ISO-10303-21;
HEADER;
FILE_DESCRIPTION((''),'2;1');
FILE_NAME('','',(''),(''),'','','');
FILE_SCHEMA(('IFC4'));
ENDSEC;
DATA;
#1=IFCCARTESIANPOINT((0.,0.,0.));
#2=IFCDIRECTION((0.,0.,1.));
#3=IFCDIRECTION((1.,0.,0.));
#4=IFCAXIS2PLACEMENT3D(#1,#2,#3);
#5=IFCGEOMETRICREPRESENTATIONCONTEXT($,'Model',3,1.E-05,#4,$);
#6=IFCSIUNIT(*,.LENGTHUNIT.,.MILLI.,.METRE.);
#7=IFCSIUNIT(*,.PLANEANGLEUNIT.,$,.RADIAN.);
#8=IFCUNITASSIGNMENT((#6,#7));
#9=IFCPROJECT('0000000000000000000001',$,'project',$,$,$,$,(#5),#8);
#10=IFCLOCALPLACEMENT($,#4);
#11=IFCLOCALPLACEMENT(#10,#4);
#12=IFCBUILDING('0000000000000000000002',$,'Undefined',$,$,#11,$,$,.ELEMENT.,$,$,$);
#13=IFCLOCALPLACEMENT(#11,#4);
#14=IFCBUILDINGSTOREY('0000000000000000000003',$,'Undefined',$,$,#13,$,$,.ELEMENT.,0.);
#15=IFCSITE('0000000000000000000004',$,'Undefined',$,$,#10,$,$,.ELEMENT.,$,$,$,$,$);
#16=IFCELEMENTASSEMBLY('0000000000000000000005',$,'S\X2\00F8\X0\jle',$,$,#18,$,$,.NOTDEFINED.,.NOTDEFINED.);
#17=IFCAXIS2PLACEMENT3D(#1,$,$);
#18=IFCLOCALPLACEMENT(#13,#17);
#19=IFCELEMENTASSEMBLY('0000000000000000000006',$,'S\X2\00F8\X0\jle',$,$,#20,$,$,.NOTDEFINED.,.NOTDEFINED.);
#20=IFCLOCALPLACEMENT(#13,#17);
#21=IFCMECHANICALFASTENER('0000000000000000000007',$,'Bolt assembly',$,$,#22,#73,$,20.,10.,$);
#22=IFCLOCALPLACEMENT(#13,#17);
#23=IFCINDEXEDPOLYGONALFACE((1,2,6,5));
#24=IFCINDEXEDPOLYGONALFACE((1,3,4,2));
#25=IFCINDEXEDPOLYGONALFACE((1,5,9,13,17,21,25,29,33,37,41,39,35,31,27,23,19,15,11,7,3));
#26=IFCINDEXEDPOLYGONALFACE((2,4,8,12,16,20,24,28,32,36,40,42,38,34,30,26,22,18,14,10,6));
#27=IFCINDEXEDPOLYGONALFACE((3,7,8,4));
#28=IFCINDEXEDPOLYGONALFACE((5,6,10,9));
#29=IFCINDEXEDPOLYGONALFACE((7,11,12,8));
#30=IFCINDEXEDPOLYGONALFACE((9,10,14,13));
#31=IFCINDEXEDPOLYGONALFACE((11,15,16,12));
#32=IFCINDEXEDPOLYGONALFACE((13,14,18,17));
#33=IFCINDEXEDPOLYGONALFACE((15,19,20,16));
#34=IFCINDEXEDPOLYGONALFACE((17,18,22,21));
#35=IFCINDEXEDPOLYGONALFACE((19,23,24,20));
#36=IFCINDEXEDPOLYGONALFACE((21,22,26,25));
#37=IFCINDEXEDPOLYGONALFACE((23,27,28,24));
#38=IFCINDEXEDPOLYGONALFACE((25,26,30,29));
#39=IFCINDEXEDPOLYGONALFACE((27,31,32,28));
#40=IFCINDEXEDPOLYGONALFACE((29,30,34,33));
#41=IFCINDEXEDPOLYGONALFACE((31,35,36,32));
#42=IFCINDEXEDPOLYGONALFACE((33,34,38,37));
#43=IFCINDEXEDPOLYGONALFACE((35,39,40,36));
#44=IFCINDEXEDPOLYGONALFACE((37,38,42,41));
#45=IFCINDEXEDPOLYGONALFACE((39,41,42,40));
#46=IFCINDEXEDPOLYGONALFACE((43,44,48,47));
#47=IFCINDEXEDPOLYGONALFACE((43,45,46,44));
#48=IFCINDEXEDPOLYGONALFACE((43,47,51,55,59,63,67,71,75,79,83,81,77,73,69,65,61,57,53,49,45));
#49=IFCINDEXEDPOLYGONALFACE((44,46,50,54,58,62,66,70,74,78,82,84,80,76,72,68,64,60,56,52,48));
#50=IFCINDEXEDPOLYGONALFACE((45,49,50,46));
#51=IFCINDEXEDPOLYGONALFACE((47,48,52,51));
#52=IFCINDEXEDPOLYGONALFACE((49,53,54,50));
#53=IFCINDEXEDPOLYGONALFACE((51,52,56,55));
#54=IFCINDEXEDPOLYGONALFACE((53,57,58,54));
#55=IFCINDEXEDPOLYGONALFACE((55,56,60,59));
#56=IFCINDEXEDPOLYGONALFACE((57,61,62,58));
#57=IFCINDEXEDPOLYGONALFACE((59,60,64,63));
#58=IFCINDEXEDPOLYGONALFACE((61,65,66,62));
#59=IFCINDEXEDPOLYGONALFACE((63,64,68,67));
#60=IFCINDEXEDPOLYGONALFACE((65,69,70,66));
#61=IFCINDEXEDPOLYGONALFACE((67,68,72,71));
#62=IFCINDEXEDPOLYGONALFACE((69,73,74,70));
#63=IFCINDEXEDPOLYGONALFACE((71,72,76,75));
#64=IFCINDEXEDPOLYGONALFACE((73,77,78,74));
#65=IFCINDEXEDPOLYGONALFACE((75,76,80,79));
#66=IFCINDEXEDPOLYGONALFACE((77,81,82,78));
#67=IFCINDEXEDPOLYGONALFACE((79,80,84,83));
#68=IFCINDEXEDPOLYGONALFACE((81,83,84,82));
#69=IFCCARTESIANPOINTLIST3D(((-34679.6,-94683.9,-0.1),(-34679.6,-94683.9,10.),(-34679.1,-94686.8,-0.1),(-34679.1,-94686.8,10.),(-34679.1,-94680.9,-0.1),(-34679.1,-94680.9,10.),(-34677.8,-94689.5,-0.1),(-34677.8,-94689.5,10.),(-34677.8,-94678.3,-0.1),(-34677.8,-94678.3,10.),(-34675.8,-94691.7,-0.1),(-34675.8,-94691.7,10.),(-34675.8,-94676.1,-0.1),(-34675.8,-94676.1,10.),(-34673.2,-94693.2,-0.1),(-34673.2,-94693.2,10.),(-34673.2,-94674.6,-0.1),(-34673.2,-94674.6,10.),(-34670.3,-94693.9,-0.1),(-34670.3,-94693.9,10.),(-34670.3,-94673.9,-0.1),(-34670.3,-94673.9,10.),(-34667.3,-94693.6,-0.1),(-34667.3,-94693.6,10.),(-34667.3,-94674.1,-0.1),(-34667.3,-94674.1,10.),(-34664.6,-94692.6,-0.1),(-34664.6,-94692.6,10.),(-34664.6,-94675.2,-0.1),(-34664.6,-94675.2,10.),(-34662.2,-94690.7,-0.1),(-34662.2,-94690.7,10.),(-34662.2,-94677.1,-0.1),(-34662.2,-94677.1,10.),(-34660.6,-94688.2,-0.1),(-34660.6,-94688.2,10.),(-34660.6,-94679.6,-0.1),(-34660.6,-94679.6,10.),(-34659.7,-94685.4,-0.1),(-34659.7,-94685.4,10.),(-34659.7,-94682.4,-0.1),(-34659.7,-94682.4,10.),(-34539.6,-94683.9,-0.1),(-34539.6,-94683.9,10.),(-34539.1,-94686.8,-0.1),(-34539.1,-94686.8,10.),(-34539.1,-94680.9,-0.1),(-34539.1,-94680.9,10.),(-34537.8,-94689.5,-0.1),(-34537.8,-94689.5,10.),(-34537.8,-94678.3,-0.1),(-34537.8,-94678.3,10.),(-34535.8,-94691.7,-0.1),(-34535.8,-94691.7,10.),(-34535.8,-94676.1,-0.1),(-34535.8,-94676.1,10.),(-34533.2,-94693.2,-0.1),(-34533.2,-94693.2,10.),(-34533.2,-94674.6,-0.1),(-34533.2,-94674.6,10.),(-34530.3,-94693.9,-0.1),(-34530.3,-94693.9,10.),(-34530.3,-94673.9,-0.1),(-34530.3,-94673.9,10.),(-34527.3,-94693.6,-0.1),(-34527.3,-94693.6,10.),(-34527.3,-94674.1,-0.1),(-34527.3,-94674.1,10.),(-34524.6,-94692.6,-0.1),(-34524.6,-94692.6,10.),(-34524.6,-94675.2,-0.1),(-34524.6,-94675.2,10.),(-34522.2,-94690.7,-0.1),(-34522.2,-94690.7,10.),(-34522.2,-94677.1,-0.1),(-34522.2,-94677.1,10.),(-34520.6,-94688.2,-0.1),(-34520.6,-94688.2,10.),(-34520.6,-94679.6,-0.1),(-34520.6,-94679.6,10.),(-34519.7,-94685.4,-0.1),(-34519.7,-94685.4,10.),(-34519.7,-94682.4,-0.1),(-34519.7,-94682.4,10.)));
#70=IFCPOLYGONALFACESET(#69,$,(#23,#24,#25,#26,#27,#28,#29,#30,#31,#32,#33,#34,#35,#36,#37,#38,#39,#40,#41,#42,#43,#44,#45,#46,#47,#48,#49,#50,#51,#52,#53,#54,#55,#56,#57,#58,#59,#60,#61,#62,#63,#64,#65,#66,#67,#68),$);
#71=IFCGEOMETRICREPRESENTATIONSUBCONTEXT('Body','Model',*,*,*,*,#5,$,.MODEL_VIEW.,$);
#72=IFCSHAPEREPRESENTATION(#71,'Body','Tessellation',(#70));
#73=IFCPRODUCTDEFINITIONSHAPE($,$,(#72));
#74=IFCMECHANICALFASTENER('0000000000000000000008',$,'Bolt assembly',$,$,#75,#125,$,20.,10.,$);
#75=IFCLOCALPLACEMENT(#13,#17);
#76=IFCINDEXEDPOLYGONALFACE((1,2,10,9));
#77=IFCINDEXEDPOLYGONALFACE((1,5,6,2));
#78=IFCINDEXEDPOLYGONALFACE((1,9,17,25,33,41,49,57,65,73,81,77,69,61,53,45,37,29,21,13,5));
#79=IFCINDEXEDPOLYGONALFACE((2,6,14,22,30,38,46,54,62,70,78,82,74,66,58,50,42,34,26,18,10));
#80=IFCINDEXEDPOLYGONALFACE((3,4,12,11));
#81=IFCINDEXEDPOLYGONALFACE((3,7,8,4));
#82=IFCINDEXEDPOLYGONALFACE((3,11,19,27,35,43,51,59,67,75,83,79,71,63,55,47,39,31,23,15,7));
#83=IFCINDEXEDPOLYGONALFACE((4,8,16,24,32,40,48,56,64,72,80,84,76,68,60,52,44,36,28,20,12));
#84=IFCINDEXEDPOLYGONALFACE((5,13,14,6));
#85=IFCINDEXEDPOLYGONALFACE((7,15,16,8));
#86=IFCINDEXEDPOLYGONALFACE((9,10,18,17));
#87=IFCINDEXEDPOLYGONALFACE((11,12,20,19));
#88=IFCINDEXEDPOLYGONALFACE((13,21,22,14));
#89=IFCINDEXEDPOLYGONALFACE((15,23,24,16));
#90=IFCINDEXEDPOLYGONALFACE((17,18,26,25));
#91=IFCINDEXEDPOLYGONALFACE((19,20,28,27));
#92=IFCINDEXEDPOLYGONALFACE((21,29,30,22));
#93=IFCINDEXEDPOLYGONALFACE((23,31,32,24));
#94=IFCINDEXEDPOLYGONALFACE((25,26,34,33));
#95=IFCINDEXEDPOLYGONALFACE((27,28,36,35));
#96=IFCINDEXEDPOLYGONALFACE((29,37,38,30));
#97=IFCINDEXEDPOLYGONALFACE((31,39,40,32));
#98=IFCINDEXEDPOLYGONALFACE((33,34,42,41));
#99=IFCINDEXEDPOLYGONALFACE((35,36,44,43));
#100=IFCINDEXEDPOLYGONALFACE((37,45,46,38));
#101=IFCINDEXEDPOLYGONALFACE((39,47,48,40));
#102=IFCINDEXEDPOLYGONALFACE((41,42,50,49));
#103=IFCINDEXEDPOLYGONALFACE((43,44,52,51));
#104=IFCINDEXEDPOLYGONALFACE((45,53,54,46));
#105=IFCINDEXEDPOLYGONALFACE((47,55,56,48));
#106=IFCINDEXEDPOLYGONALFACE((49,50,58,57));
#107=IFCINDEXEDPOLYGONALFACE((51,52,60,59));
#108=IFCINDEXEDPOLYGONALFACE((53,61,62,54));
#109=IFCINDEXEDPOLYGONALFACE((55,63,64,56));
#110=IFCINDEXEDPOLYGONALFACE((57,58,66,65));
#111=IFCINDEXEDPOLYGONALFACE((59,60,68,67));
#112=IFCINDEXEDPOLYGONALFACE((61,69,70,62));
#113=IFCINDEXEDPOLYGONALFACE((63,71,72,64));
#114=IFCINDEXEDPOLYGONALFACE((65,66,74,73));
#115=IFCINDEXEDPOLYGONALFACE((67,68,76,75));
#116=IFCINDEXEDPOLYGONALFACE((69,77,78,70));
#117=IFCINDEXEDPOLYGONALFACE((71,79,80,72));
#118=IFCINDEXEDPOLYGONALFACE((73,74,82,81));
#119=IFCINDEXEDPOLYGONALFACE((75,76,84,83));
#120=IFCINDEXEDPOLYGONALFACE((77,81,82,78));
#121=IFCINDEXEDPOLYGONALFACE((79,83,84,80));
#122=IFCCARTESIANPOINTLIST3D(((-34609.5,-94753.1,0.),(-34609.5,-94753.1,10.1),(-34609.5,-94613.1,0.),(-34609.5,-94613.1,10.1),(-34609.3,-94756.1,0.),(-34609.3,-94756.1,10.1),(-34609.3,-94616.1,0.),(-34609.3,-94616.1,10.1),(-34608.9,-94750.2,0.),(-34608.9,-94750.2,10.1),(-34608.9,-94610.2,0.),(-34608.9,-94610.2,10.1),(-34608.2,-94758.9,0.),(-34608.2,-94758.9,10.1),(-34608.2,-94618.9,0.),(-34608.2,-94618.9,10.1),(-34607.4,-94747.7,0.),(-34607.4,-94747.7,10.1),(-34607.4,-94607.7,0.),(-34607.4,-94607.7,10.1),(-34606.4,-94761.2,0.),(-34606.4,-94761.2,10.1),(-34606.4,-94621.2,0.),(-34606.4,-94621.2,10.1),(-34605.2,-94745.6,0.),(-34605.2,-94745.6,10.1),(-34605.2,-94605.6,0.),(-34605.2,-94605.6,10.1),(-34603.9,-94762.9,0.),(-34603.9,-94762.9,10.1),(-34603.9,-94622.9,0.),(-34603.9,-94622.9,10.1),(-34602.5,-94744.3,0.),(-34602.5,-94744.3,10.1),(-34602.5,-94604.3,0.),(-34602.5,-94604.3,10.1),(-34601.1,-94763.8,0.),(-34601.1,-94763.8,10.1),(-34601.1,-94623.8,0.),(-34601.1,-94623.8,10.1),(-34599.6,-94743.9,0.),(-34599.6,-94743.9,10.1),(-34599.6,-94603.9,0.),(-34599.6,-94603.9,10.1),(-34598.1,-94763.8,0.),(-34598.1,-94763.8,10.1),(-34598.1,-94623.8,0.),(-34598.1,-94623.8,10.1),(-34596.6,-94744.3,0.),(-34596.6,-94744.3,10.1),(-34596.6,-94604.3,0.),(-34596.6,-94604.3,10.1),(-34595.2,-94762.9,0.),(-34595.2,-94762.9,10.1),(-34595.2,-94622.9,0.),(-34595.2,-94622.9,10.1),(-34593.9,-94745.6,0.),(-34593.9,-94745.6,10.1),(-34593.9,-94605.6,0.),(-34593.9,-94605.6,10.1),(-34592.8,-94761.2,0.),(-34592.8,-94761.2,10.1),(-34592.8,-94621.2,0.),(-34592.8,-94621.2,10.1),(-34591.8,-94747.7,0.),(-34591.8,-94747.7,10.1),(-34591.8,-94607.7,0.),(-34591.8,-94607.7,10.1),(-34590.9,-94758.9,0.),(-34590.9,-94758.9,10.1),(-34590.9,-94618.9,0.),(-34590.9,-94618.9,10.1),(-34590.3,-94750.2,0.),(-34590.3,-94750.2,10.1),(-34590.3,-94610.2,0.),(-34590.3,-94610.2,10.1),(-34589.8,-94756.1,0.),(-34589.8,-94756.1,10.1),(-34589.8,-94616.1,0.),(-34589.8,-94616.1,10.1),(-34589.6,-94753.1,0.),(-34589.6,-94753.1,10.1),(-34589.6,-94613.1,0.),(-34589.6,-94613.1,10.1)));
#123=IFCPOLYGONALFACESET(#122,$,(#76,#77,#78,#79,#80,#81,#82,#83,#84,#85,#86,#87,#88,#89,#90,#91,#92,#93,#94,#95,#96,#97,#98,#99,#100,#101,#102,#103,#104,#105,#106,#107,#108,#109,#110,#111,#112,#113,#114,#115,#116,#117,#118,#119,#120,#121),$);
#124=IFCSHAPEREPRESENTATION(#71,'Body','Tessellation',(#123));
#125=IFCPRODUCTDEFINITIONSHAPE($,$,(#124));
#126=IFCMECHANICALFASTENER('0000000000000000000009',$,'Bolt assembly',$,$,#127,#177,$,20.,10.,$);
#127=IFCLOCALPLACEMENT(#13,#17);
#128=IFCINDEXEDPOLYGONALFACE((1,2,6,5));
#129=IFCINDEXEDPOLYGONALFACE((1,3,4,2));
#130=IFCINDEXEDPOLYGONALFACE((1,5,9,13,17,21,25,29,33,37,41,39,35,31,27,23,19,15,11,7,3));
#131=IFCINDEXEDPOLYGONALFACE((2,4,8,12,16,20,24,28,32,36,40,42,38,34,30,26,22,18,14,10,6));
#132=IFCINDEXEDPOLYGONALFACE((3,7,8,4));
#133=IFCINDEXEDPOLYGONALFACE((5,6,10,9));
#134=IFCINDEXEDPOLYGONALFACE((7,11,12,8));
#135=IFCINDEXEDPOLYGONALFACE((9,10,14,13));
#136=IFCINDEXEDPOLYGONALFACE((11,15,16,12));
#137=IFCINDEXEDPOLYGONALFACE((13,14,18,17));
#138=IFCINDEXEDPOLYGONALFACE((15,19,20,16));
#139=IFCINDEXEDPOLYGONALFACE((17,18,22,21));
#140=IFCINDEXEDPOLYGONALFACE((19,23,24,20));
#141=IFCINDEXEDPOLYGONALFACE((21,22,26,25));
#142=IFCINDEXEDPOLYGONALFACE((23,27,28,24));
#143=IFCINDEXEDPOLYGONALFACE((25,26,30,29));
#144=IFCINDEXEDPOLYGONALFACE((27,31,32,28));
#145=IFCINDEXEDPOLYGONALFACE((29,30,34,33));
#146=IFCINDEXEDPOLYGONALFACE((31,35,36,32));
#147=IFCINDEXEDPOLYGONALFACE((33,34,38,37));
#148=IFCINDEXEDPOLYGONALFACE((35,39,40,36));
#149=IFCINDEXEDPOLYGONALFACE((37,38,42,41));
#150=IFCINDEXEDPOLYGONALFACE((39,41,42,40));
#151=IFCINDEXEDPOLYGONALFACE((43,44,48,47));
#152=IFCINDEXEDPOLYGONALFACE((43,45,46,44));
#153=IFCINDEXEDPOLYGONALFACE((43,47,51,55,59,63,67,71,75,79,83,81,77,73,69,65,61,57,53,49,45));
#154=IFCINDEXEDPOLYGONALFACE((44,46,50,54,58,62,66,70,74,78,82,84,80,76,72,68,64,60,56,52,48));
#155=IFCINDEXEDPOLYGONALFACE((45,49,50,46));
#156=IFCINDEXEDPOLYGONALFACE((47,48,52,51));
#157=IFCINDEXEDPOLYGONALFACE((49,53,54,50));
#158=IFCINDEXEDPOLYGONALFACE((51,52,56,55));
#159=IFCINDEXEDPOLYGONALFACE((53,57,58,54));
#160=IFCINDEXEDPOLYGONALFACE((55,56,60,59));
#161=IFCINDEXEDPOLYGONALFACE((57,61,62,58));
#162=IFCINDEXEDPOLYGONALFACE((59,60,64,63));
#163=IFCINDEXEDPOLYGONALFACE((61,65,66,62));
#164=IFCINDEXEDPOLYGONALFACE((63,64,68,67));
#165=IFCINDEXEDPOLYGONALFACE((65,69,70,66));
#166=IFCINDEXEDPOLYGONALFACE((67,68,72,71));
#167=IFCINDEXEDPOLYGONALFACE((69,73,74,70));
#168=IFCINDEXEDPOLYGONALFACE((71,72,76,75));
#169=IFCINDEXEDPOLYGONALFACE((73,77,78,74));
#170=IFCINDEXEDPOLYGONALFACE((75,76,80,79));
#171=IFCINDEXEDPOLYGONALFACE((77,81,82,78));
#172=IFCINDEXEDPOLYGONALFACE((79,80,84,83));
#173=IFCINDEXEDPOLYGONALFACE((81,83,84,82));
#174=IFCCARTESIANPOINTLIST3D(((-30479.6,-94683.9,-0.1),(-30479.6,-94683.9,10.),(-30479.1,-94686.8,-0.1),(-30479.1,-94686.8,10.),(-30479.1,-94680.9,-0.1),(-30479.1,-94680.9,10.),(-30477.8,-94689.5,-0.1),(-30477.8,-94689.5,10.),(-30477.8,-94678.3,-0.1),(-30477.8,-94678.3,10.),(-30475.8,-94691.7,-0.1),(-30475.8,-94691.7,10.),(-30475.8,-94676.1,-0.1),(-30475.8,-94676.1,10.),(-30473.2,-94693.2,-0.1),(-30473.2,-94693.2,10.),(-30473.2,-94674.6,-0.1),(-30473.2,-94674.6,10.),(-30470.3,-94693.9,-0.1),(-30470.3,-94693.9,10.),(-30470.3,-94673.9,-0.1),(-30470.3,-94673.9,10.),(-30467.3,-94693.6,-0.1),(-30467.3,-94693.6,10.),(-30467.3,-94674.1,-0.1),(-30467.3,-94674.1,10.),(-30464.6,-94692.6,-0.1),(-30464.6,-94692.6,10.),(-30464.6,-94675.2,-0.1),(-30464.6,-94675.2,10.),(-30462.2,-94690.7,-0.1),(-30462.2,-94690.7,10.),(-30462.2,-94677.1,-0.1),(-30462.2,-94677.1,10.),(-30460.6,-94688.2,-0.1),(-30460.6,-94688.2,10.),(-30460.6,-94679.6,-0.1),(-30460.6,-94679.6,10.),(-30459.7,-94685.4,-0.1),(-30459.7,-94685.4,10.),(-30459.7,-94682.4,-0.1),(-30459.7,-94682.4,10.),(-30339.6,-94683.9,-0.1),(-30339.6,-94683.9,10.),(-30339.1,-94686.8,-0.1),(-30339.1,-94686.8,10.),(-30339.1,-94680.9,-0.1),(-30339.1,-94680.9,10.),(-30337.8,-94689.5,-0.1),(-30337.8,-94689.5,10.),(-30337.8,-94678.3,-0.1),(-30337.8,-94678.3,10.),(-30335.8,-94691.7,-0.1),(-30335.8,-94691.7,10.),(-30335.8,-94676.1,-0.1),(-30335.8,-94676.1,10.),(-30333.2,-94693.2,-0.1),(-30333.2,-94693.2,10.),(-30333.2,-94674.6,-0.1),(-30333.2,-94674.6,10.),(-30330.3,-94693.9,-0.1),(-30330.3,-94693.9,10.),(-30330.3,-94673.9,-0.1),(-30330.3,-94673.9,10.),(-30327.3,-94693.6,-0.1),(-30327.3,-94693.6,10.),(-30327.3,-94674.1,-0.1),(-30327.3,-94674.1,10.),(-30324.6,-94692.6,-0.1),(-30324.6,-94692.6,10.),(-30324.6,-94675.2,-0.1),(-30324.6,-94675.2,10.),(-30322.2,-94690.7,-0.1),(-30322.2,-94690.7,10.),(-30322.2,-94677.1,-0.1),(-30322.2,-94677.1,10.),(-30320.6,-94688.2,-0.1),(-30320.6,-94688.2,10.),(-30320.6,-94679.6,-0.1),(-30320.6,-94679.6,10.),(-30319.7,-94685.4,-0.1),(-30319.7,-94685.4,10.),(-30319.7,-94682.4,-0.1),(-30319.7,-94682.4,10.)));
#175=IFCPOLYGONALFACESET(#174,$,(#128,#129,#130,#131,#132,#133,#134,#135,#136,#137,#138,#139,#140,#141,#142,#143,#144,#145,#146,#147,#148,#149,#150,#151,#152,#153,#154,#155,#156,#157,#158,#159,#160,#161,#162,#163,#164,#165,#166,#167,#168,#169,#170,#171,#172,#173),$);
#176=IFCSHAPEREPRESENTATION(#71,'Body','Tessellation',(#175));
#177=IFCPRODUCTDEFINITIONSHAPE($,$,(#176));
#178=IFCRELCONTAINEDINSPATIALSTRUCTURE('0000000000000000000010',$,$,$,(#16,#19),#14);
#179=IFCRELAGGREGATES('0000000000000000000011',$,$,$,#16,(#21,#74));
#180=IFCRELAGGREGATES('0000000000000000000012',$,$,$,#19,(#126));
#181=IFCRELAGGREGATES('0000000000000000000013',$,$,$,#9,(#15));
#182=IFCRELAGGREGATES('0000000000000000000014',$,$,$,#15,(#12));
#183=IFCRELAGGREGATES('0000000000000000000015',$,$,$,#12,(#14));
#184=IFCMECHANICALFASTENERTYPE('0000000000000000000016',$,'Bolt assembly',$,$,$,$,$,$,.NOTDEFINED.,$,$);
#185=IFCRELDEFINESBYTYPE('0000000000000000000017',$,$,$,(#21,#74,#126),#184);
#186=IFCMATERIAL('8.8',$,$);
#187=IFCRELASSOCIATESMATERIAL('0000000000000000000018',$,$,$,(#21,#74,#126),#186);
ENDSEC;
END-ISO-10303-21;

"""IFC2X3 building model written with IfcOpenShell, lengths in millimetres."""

from ifc_helpers import new_model, si_unit, frame, origin_with_axes, origin_2d_with_axis, place, context, subcontext, project, spatial, circle, extrude, source, transform, mapped, material, type_object, element, aggregate, save


model = new_model("IFC2X3")

# Units and contexts
model_context = context("Model", 3, precision=1e-05, world=origin_with_axes())
body_context = subcontext(model_context, "Body", "Model", "MODEL_VIEW")
ifc_project = project(units=[si_unit("LENGTHUNIT", "METRE", prefix="MILLI"), si_unit("PLANEANGLEUNIT", "RADIAN")], contexts=[model_context])

# Site, building, storey
site_placement = place(None, origin_with_axes())
site = spatial("IfcSite", under=ifc_project, at=site_placement, Name="Undefined", CompositionType="ELEMENT")
building_placement = place(site_placement, origin_with_axes())
building = spatial("IfcBuilding", under=site, at=building_placement, Name="Undefined", CompositionType="ELEMENT")
storey_placement = place(building_placement, origin_with_axes())
storey = spatial("IfcBuildingStorey", under=building, at=storey_placement, Name="Undefined", CompositionType="ELEMENT", Elevation=0.0)

# Element assemblies
assembly_1_placement = place(storey_placement, origin_with_axes())
assembly_1 = element("IfcElementAssembly", 1, at=assembly_1_placement, inside=storey, Name="Søjle", AssemblyPlace="NOTDEFINED", PredefinedType="NOTDEFINED")
assembly_2_placement = place(storey_placement, origin_with_axes())
assembly_2 = element("IfcElementAssembly", 2, at=assembly_2_placement, inside=storey, Name="Søjle", AssemblyPlace="NOTDEFINED", PredefinedType="NOTDEFINED")

# Mechanical fasteners
ifc_material_1 = material(Name="8.8")
mechanical_fastener_type = type_object("IfcMechanicalFastenerType", Name="Bolt assembly")
shared_shape_1 = source(origin_with_axes(), body_context, "Body", "SweptSolid", [
    extrude(circle(Radius=10.0, at=origin_2d_with_axis()), frame((0.0, -10.0, 0.0), z_axis=(0.0, 1.0, 0.0), x_axis=(1.0, 0.0, 0.0)), (0.0, 0.0, 1.0), 10.1),
])
mechanical_fastener_1_placement = place(assembly_1_placement, frame((-34529.6, -94683.9, 0.0), z_axis=(0.0, -1.0, 0.0), x_axis=(-1.0, 0.0, 0.0)))
mechanical_fastener_1 = element("IfcMechanicalFastener", 3, at=mechanical_fastener_1_placement, type_object=mechanical_fastener_type, material=ifc_material_1, Name="Bolt assembly", NominalDiameter=20.0, NominalLength=10.0, context=body_context, shape_type="MappedRepresentation", body=[
    mapped(shared_shape_1, transform((0.0, 0.0, 0.0))),
    mapped(shared_shape_1, transform((140.0, 0.0, 0.0))),
])
mechanical_fastener_2_placement = place(assembly_1_placement, frame((-34599.6, -94753.9, 10.0), z_axis=(1.0, 0.0, 0.0), x_axis=(0.0, 1.0, 0.0)))
mechanical_fastener_2 = element("IfcMechanicalFastener", 4, at=mechanical_fastener_2_placement, type_object=mechanical_fastener_type, material=ifc_material_1, Name="Bolt assembly", NominalDiameter=20.0, NominalLength=10.0, context=body_context, shape_type="MappedRepresentation", body=[
    mapped(shared_shape_1, transform((0.0, 0.0, 0.0))),
    mapped(shared_shape_1, transform((140.0, 0.0, 0.0))),
])
mechanical_fastener_3_placement = place(assembly_2_placement, frame((-30329.6, -94683.9, 0.0), z_axis=(0.0, -1.0, 0.0), x_axis=(-1.0, 0.0, 0.0)))
mechanical_fastener_3 = element("IfcMechanicalFastener", 5, at=mechanical_fastener_3_placement, type_object=mechanical_fastener_type, material=ifc_material_1, Name="Bolt assembly", NominalDiameter=20.0, NominalLength=10.0, context=body_context, shape_type="MappedRepresentation", body=[
    mapped(shared_shape_1, transform((0.0, 0.0, 0.0))),
    mapped(shared_shape_1, transform((140.0, 0.0, 0.0))),
])
aggregate(assembly_1, [mechanical_fastener_1, mechanical_fastener_2])
aggregate(assembly_2, [mechanical_fastener_3])

save(model, "model.ifc")
